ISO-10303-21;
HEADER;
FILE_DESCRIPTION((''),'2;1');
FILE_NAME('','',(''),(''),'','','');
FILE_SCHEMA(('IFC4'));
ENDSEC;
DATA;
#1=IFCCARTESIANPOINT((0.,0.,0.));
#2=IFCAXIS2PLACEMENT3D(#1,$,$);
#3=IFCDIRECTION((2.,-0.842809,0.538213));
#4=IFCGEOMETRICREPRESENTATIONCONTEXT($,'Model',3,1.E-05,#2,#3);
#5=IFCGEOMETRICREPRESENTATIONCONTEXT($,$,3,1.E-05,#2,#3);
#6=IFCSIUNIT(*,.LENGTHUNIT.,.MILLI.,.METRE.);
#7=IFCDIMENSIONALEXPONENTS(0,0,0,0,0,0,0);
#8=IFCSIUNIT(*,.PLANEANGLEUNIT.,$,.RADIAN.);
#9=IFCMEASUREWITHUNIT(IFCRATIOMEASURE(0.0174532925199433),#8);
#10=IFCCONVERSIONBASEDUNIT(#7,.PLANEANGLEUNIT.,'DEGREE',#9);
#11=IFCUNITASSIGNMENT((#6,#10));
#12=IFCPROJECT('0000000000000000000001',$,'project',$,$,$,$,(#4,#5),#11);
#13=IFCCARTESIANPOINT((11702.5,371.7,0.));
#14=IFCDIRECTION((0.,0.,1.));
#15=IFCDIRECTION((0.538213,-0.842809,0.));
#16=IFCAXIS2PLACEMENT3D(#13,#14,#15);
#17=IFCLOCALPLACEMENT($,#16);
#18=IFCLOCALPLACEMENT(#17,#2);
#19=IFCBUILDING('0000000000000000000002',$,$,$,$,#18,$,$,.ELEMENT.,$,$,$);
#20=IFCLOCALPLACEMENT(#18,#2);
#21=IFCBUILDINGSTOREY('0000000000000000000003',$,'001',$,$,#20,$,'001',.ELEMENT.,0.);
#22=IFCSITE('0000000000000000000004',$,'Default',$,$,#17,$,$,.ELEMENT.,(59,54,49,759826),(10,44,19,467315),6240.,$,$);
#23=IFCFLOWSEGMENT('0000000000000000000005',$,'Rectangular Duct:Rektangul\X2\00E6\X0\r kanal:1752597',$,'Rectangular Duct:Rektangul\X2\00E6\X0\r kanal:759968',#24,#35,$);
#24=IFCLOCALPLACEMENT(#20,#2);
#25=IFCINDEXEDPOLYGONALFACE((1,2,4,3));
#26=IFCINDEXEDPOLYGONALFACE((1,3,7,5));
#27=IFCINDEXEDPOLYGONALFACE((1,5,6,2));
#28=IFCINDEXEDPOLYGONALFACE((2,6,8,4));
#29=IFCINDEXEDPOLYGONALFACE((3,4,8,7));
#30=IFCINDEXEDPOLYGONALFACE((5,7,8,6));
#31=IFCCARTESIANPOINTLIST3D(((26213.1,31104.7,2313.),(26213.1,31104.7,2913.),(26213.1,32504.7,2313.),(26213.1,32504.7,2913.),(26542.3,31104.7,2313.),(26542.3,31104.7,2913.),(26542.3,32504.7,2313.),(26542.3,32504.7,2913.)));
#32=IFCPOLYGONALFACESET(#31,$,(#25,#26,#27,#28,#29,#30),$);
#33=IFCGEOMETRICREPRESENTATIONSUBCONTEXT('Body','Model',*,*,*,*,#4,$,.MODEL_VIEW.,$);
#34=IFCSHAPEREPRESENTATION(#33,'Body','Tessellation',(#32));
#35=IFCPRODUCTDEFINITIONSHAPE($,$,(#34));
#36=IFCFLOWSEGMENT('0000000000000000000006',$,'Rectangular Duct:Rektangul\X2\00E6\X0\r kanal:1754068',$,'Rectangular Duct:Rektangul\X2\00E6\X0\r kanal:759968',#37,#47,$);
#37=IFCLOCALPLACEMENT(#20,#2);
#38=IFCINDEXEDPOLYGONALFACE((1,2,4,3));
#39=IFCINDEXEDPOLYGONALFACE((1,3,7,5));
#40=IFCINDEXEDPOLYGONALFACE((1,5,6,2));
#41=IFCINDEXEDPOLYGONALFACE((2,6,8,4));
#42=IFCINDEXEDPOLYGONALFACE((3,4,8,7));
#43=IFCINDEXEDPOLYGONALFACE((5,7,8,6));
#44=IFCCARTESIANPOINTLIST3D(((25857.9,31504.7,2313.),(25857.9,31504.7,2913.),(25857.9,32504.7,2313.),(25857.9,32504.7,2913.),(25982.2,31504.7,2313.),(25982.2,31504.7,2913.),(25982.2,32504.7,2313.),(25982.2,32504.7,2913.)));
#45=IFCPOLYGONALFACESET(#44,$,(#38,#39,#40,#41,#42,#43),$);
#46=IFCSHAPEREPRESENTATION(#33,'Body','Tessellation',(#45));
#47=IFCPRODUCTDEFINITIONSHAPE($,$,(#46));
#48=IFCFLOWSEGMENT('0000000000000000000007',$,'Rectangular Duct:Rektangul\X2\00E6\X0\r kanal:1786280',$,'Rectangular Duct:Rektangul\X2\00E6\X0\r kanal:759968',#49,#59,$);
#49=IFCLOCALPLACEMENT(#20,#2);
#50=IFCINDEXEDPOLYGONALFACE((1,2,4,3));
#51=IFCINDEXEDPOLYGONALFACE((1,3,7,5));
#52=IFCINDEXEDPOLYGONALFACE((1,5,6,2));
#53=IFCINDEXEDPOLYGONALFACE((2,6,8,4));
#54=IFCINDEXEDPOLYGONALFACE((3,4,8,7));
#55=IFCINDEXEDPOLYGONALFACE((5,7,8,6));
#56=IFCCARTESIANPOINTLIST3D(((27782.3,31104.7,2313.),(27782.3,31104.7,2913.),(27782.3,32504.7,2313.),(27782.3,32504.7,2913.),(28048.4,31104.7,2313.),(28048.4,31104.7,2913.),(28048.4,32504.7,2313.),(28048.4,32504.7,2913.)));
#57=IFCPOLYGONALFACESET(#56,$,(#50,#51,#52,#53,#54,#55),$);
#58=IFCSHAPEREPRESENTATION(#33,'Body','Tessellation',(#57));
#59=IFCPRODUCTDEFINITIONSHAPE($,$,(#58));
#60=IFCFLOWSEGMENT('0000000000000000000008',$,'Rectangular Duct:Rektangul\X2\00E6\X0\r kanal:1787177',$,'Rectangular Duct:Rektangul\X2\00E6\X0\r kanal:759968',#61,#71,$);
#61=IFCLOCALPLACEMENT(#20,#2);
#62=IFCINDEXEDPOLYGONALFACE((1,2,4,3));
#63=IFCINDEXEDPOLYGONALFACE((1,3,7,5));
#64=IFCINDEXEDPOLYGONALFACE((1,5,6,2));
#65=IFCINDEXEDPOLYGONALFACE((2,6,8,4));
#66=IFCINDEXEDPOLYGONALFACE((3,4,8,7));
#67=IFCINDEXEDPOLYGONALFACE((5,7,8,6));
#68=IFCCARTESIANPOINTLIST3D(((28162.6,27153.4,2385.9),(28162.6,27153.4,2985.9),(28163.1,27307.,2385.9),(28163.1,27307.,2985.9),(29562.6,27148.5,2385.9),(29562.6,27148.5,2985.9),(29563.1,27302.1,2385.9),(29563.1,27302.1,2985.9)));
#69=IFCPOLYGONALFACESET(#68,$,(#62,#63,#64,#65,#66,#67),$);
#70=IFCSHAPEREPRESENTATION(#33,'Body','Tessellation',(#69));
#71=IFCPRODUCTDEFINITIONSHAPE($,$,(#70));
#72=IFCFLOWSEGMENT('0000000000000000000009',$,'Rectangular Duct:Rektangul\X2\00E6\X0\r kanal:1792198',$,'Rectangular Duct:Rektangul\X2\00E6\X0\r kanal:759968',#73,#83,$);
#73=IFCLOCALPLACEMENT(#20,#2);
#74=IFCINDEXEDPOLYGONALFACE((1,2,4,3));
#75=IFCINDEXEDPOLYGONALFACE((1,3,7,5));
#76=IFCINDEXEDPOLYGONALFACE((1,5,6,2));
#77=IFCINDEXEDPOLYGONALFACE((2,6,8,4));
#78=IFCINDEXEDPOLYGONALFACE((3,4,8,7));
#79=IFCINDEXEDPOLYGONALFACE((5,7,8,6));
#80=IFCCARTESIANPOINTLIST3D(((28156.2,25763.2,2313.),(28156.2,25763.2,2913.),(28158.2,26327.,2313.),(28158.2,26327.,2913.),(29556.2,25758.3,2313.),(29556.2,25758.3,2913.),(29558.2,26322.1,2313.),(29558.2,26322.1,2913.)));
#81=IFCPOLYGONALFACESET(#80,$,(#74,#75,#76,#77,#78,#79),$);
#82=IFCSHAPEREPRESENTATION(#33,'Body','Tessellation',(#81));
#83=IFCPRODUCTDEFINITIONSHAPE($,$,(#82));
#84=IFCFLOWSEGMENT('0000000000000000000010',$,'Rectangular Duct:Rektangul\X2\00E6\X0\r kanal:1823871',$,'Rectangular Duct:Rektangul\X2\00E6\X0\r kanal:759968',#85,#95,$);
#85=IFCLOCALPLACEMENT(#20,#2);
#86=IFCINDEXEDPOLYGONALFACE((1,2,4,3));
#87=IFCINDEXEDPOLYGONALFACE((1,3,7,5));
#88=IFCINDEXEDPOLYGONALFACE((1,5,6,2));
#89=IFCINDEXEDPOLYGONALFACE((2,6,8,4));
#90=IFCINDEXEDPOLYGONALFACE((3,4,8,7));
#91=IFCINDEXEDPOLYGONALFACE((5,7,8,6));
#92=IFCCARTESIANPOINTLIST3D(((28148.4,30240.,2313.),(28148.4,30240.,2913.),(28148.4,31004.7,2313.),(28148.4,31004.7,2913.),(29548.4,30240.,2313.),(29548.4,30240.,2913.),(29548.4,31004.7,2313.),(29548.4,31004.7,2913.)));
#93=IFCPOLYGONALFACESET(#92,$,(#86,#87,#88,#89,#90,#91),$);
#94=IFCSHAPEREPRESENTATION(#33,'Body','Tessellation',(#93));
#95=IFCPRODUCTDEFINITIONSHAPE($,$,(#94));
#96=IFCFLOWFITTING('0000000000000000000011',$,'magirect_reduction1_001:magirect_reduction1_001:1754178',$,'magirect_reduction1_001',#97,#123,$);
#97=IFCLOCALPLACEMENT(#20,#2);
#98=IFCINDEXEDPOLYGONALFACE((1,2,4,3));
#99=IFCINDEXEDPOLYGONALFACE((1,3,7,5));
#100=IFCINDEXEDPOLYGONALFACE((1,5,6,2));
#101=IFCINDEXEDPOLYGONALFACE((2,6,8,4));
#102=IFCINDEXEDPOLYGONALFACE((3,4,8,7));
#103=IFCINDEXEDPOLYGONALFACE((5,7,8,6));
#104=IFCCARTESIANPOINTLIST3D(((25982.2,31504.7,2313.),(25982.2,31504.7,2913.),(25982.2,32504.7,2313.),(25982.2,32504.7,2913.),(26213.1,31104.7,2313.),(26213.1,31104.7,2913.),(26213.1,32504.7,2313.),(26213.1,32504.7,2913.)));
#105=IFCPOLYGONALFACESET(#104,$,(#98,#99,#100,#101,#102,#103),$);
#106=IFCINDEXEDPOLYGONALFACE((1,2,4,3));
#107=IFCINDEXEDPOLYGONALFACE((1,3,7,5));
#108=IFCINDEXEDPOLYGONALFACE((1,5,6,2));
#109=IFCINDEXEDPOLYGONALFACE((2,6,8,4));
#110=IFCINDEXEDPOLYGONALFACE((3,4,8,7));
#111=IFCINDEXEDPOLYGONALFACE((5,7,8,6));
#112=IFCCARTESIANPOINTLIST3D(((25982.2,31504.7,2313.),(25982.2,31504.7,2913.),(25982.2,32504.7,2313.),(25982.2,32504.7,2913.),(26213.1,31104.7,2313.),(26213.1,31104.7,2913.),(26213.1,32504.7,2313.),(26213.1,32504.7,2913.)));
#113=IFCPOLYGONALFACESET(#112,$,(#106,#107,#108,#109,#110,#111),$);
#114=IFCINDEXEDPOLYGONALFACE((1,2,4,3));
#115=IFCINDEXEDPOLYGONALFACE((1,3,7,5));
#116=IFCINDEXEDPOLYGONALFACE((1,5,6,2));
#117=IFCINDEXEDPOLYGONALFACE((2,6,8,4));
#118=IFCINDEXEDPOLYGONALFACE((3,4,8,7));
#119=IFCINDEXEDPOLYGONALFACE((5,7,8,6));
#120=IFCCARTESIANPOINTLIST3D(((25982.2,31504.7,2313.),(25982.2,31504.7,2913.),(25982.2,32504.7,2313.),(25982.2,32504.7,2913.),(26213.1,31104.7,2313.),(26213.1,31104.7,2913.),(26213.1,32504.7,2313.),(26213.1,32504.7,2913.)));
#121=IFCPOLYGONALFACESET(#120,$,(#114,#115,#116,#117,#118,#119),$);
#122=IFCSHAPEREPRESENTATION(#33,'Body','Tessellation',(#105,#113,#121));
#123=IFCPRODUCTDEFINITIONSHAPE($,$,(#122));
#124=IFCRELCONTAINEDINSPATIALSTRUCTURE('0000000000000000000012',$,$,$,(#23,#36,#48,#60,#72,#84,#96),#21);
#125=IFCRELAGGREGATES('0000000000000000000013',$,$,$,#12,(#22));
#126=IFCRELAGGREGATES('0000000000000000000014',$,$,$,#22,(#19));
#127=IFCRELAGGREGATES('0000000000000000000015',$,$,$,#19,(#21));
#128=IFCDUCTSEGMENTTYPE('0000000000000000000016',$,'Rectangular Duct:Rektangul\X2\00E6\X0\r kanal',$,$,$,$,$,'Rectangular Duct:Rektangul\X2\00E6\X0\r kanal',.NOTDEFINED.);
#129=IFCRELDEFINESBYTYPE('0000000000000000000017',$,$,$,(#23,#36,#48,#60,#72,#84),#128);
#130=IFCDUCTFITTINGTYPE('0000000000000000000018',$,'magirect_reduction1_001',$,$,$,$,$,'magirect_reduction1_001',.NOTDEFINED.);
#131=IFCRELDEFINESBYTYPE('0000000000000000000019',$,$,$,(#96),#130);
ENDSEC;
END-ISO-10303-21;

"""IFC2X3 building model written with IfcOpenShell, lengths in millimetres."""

from ifc_helpers import new_model, entity, si_unit, converted_unit, direction, frame, frame_2d, origin, place, context, subcontext, project, spatial, polyline, rectangle, outline, extrude, source, transform, mapped, type_object, type_shapes, element, save


model = new_model("IFC2X3")

# Units and contexts
model_context = context("Model", 3, precision=1e-05, world=origin(), true_north=direction((2.0, -0.842809, 0.538213)))
context_of_model = context(None, 3, precision=1e-05, world=origin(), true_north=direction((2.0, -0.842809, 0.538213)))
body_context = subcontext(model_context, "Body", "Model", "MODEL_VIEW")
ifc_project = project(units=[si_unit("LENGTHUNIT", "METRE", prefix="MILLI"), converted_unit("PLANEANGLEUNIT", "DEGREE", entity("IfcRatioMeasure", 0.0174532925199433), si_unit("PLANEANGLEUNIT", "RADIAN"), dimensions=[0, 0, 0, 0, 0, 0, 0])], contexts=[model_context, context_of_model])

# Site, building, storey
site_placement = place(None, frame((11702.5, 371.7, 0.0), z_axis=(0.0, 0.0, 1.0), x_axis=(0.538213, -0.842809, 0.0)))
site = spatial("IfcSite", under=ifc_project, at=site_placement, Name="Default", CompositionType="ELEMENT", RefLatitude=(59, 54, 49, 759826), RefLongitude=(10, 44, 19, 467315), RefElevation=6240.0)
building_placement = place(site_placement, origin())
building = spatial("IfcBuilding", under=site, at=building_placement, CompositionType="ELEMENT")
storey_placement = place(building_placement, origin())
storey = spatial("IfcBuildingStorey", under=building, at=storey_placement, Name="001", LongName="001", CompositionType="ELEMENT", Elevation=0.0)

# Flow segments
duct_segment_type = type_object("IfcDuctSegmentType", Name="Rectangular Duct:Rektangulær kanal", ElementType="Rectangular Duct:Rektangulær kanal", PredefinedType="NOTDEFINED")
flow_segment_1_placement = place(storey_placement, origin())
element("IfcFlowSegment", 1, at=flow_segment_1_placement, inside=storey, type_object=duct_segment_type, Name="Rectangular Duct:Rektangulær kanal:1752597", ObjectType="Rectangular Duct:Rektangulær kanal:759968", context=body_context, shape_type="SweptSolid", body=[
    extrude(rectangle(XDim=329.2, YDim=1400.0, at=frame_2d((0.0, 0.0), x_axis=(1.0, 0.0))), frame((26377.7, 31804.7, 2313.0), z_axis=(0.0, 0.0, 1.0), x_axis=(-1.0, 0.0, 0.0)), (0.0, 0.0, 1.0), 600.0),
])
flow_segment_2_placement = place(storey_placement, origin())
element("IfcFlowSegment", 2, at=flow_segment_2_placement, inside=storey, type_object=duct_segment_type, Name="Rectangular Duct:Rektangulær kanal:1754068", ObjectType="Rectangular Duct:Rektangulær kanal:759968", context=body_context, shape_type="SweptSolid", body=[
    extrude(rectangle(XDim=124.2, YDim=1000.0, at=frame_2d((0.0, 0.0), x_axis=(1.0, 0.0))), frame((25920.1, 32004.7, 2313.0)), (0.0, 0.0, 1.0), 600.0),
])
flow_segment_3_placement = place(storey_placement, origin())
element("IfcFlowSegment", 3, at=flow_segment_3_placement, inside=storey, type_object=duct_segment_type, Name="Rectangular Duct:Rektangulær kanal:1786280", ObjectType="Rectangular Duct:Rektangulær kanal:759968", context=body_context, shape_type="SweptSolid", body=[
    extrude(rectangle(XDim=266.0, YDim=1400.0, at=frame_2d((0.0, 0.0), x_axis=(1.0, 0.0))), frame((27915.3, 31804.7, 2313.0), z_axis=(0.0, 0.0, 1.0), x_axis=(-1.0, 0.0, 0.0)), (0.0, 0.0, 1.0), 600.0),
])
flow_segment_4_placement = place(storey_placement, origin())
element("IfcFlowSegment", 4, at=flow_segment_4_placement, inside=storey, type_object=duct_segment_type, Name="Rectangular Duct:Rektangulær kanal:1787177", ObjectType="Rectangular Duct:Rektangulær kanal:759968", context=body_context, shape_type="SweptSolid", body=[
    extrude(rectangle(XDim=153.6, YDim=1400.0, at=frame_2d((0.0, 0.0), x_axis=(1.0, 0.0))), frame((28862.8, 27227.8, 2385.9), z_axis=(0.0, 0.0, 1.0), x_axis=(0.003502, 0.999994, 0.0)), (0.0, 0.0, 1.0), 600.0),
])
flow_segment_5_placement = place(storey_placement, origin())
element("IfcFlowSegment", 5, at=flow_segment_5_placement, inside=storey, type_object=duct_segment_type, Name="Rectangular Duct:Rektangulær kanal:1792198", ObjectType="Rectangular Duct:Rektangulær kanal:759968", context=body_context, shape_type="SweptSolid", body=[
    extrude(rectangle(XDim=563.9, YDim=1400.0, at=frame_2d((0.0, 0.0), x_axis=(1.0, 0.0))), frame((28857.2, 26042.7, 2313.0), z_axis=(0.0, 0.0, 1.0), x_axis=(0.003502, 0.999994, 0.0)), (0.0, 0.0, 1.0), 600.0),
])
flow_segment_6_placement = place(storey_placement, origin())
element("IfcFlowSegment", 6, at=flow_segment_6_placement, inside=storey, type_object=duct_segment_type, Name="Rectangular Duct:Rektangulær kanal:1823871", ObjectType="Rectangular Duct:Rektangulær kanal:759968", context=body_context, shape_type="SweptSolid", body=[
    extrude(rectangle(XDim=764.7, YDim=1400.0, at=frame_2d((0.0, 0.0), x_axis=(1.0, 0.0))), frame((28848.4, 30622.3, 2313.0), z_axis=(0.0, 0.0, 1.0), x_axis=(0.0, -1.0, 0.0)), (0.0, 0.0, 1.0), 600.0),
])

# Flow fitting
duct_fitting_type_1 = type_object("IfcDuctFittingType", Name="magirect_reduction1_001", ElementType="magirect_reduction1_001", PredefinedType="NOTDEFINED")
shared_shape_1 = source(origin(), body_context, "Body", "SweptSolid", [
    extrude(outline(polyline([(288.7, -300.0), (750.6, -300.0), (-461.9, 400.0), (-577.4, 200.0), (288.7, -300.0)])), frame((115.5, -100.0, -300.0), z_axis=(0.0, 0.0, 1.0), x_axis=(0.5, -0.866025, 0.0)), (0.0, 0.0, 1.0), 600.0),
    extrude(outline(polyline([(288.7, -300.0), (750.6, -300.0), (-461.9, 400.0), (-577.4, 200.0), (288.7, -300.0)])), frame((115.5, -100.0, -300.0), z_axis=(0.0, 0.0, 1.0), x_axis=(0.5, -0.866025, 0.0)), (0.0, 0.0, 1.0), 600.0),
    extrude(outline(polyline([(288.7, -300.0), (750.6, -300.0), (-461.9, 400.0), (-577.4, 200.0), (288.7, -300.0)])), frame((115.5, -100.0, -300.0), z_axis=(0.0, 0.0, 1.0), x_axis=(0.5, -0.866025, 0.0)), (0.0, 0.0, 1.0), 600.0),
])
type_shapes(duct_fitting_type_1, [shared_shape_1])
flow_fitting_1_placement = place(storey_placement, frame((25982.2, 32004.7, 2613.0)))
element("IfcFlowFitting", 7, at=flow_fitting_1_placement, inside=storey, type_object=duct_fitting_type_1, Name="magirect_reduction1_001:magirect_reduction1_001:1754178", ObjectType="magirect_reduction1_001", context=body_context, shape_type="MappedRepresentation", body=[
    mapped(shared_shape_1, transform((0.0, 0.0, 0.0), scale=1.0)),
])

save(model, "model.ifc")
